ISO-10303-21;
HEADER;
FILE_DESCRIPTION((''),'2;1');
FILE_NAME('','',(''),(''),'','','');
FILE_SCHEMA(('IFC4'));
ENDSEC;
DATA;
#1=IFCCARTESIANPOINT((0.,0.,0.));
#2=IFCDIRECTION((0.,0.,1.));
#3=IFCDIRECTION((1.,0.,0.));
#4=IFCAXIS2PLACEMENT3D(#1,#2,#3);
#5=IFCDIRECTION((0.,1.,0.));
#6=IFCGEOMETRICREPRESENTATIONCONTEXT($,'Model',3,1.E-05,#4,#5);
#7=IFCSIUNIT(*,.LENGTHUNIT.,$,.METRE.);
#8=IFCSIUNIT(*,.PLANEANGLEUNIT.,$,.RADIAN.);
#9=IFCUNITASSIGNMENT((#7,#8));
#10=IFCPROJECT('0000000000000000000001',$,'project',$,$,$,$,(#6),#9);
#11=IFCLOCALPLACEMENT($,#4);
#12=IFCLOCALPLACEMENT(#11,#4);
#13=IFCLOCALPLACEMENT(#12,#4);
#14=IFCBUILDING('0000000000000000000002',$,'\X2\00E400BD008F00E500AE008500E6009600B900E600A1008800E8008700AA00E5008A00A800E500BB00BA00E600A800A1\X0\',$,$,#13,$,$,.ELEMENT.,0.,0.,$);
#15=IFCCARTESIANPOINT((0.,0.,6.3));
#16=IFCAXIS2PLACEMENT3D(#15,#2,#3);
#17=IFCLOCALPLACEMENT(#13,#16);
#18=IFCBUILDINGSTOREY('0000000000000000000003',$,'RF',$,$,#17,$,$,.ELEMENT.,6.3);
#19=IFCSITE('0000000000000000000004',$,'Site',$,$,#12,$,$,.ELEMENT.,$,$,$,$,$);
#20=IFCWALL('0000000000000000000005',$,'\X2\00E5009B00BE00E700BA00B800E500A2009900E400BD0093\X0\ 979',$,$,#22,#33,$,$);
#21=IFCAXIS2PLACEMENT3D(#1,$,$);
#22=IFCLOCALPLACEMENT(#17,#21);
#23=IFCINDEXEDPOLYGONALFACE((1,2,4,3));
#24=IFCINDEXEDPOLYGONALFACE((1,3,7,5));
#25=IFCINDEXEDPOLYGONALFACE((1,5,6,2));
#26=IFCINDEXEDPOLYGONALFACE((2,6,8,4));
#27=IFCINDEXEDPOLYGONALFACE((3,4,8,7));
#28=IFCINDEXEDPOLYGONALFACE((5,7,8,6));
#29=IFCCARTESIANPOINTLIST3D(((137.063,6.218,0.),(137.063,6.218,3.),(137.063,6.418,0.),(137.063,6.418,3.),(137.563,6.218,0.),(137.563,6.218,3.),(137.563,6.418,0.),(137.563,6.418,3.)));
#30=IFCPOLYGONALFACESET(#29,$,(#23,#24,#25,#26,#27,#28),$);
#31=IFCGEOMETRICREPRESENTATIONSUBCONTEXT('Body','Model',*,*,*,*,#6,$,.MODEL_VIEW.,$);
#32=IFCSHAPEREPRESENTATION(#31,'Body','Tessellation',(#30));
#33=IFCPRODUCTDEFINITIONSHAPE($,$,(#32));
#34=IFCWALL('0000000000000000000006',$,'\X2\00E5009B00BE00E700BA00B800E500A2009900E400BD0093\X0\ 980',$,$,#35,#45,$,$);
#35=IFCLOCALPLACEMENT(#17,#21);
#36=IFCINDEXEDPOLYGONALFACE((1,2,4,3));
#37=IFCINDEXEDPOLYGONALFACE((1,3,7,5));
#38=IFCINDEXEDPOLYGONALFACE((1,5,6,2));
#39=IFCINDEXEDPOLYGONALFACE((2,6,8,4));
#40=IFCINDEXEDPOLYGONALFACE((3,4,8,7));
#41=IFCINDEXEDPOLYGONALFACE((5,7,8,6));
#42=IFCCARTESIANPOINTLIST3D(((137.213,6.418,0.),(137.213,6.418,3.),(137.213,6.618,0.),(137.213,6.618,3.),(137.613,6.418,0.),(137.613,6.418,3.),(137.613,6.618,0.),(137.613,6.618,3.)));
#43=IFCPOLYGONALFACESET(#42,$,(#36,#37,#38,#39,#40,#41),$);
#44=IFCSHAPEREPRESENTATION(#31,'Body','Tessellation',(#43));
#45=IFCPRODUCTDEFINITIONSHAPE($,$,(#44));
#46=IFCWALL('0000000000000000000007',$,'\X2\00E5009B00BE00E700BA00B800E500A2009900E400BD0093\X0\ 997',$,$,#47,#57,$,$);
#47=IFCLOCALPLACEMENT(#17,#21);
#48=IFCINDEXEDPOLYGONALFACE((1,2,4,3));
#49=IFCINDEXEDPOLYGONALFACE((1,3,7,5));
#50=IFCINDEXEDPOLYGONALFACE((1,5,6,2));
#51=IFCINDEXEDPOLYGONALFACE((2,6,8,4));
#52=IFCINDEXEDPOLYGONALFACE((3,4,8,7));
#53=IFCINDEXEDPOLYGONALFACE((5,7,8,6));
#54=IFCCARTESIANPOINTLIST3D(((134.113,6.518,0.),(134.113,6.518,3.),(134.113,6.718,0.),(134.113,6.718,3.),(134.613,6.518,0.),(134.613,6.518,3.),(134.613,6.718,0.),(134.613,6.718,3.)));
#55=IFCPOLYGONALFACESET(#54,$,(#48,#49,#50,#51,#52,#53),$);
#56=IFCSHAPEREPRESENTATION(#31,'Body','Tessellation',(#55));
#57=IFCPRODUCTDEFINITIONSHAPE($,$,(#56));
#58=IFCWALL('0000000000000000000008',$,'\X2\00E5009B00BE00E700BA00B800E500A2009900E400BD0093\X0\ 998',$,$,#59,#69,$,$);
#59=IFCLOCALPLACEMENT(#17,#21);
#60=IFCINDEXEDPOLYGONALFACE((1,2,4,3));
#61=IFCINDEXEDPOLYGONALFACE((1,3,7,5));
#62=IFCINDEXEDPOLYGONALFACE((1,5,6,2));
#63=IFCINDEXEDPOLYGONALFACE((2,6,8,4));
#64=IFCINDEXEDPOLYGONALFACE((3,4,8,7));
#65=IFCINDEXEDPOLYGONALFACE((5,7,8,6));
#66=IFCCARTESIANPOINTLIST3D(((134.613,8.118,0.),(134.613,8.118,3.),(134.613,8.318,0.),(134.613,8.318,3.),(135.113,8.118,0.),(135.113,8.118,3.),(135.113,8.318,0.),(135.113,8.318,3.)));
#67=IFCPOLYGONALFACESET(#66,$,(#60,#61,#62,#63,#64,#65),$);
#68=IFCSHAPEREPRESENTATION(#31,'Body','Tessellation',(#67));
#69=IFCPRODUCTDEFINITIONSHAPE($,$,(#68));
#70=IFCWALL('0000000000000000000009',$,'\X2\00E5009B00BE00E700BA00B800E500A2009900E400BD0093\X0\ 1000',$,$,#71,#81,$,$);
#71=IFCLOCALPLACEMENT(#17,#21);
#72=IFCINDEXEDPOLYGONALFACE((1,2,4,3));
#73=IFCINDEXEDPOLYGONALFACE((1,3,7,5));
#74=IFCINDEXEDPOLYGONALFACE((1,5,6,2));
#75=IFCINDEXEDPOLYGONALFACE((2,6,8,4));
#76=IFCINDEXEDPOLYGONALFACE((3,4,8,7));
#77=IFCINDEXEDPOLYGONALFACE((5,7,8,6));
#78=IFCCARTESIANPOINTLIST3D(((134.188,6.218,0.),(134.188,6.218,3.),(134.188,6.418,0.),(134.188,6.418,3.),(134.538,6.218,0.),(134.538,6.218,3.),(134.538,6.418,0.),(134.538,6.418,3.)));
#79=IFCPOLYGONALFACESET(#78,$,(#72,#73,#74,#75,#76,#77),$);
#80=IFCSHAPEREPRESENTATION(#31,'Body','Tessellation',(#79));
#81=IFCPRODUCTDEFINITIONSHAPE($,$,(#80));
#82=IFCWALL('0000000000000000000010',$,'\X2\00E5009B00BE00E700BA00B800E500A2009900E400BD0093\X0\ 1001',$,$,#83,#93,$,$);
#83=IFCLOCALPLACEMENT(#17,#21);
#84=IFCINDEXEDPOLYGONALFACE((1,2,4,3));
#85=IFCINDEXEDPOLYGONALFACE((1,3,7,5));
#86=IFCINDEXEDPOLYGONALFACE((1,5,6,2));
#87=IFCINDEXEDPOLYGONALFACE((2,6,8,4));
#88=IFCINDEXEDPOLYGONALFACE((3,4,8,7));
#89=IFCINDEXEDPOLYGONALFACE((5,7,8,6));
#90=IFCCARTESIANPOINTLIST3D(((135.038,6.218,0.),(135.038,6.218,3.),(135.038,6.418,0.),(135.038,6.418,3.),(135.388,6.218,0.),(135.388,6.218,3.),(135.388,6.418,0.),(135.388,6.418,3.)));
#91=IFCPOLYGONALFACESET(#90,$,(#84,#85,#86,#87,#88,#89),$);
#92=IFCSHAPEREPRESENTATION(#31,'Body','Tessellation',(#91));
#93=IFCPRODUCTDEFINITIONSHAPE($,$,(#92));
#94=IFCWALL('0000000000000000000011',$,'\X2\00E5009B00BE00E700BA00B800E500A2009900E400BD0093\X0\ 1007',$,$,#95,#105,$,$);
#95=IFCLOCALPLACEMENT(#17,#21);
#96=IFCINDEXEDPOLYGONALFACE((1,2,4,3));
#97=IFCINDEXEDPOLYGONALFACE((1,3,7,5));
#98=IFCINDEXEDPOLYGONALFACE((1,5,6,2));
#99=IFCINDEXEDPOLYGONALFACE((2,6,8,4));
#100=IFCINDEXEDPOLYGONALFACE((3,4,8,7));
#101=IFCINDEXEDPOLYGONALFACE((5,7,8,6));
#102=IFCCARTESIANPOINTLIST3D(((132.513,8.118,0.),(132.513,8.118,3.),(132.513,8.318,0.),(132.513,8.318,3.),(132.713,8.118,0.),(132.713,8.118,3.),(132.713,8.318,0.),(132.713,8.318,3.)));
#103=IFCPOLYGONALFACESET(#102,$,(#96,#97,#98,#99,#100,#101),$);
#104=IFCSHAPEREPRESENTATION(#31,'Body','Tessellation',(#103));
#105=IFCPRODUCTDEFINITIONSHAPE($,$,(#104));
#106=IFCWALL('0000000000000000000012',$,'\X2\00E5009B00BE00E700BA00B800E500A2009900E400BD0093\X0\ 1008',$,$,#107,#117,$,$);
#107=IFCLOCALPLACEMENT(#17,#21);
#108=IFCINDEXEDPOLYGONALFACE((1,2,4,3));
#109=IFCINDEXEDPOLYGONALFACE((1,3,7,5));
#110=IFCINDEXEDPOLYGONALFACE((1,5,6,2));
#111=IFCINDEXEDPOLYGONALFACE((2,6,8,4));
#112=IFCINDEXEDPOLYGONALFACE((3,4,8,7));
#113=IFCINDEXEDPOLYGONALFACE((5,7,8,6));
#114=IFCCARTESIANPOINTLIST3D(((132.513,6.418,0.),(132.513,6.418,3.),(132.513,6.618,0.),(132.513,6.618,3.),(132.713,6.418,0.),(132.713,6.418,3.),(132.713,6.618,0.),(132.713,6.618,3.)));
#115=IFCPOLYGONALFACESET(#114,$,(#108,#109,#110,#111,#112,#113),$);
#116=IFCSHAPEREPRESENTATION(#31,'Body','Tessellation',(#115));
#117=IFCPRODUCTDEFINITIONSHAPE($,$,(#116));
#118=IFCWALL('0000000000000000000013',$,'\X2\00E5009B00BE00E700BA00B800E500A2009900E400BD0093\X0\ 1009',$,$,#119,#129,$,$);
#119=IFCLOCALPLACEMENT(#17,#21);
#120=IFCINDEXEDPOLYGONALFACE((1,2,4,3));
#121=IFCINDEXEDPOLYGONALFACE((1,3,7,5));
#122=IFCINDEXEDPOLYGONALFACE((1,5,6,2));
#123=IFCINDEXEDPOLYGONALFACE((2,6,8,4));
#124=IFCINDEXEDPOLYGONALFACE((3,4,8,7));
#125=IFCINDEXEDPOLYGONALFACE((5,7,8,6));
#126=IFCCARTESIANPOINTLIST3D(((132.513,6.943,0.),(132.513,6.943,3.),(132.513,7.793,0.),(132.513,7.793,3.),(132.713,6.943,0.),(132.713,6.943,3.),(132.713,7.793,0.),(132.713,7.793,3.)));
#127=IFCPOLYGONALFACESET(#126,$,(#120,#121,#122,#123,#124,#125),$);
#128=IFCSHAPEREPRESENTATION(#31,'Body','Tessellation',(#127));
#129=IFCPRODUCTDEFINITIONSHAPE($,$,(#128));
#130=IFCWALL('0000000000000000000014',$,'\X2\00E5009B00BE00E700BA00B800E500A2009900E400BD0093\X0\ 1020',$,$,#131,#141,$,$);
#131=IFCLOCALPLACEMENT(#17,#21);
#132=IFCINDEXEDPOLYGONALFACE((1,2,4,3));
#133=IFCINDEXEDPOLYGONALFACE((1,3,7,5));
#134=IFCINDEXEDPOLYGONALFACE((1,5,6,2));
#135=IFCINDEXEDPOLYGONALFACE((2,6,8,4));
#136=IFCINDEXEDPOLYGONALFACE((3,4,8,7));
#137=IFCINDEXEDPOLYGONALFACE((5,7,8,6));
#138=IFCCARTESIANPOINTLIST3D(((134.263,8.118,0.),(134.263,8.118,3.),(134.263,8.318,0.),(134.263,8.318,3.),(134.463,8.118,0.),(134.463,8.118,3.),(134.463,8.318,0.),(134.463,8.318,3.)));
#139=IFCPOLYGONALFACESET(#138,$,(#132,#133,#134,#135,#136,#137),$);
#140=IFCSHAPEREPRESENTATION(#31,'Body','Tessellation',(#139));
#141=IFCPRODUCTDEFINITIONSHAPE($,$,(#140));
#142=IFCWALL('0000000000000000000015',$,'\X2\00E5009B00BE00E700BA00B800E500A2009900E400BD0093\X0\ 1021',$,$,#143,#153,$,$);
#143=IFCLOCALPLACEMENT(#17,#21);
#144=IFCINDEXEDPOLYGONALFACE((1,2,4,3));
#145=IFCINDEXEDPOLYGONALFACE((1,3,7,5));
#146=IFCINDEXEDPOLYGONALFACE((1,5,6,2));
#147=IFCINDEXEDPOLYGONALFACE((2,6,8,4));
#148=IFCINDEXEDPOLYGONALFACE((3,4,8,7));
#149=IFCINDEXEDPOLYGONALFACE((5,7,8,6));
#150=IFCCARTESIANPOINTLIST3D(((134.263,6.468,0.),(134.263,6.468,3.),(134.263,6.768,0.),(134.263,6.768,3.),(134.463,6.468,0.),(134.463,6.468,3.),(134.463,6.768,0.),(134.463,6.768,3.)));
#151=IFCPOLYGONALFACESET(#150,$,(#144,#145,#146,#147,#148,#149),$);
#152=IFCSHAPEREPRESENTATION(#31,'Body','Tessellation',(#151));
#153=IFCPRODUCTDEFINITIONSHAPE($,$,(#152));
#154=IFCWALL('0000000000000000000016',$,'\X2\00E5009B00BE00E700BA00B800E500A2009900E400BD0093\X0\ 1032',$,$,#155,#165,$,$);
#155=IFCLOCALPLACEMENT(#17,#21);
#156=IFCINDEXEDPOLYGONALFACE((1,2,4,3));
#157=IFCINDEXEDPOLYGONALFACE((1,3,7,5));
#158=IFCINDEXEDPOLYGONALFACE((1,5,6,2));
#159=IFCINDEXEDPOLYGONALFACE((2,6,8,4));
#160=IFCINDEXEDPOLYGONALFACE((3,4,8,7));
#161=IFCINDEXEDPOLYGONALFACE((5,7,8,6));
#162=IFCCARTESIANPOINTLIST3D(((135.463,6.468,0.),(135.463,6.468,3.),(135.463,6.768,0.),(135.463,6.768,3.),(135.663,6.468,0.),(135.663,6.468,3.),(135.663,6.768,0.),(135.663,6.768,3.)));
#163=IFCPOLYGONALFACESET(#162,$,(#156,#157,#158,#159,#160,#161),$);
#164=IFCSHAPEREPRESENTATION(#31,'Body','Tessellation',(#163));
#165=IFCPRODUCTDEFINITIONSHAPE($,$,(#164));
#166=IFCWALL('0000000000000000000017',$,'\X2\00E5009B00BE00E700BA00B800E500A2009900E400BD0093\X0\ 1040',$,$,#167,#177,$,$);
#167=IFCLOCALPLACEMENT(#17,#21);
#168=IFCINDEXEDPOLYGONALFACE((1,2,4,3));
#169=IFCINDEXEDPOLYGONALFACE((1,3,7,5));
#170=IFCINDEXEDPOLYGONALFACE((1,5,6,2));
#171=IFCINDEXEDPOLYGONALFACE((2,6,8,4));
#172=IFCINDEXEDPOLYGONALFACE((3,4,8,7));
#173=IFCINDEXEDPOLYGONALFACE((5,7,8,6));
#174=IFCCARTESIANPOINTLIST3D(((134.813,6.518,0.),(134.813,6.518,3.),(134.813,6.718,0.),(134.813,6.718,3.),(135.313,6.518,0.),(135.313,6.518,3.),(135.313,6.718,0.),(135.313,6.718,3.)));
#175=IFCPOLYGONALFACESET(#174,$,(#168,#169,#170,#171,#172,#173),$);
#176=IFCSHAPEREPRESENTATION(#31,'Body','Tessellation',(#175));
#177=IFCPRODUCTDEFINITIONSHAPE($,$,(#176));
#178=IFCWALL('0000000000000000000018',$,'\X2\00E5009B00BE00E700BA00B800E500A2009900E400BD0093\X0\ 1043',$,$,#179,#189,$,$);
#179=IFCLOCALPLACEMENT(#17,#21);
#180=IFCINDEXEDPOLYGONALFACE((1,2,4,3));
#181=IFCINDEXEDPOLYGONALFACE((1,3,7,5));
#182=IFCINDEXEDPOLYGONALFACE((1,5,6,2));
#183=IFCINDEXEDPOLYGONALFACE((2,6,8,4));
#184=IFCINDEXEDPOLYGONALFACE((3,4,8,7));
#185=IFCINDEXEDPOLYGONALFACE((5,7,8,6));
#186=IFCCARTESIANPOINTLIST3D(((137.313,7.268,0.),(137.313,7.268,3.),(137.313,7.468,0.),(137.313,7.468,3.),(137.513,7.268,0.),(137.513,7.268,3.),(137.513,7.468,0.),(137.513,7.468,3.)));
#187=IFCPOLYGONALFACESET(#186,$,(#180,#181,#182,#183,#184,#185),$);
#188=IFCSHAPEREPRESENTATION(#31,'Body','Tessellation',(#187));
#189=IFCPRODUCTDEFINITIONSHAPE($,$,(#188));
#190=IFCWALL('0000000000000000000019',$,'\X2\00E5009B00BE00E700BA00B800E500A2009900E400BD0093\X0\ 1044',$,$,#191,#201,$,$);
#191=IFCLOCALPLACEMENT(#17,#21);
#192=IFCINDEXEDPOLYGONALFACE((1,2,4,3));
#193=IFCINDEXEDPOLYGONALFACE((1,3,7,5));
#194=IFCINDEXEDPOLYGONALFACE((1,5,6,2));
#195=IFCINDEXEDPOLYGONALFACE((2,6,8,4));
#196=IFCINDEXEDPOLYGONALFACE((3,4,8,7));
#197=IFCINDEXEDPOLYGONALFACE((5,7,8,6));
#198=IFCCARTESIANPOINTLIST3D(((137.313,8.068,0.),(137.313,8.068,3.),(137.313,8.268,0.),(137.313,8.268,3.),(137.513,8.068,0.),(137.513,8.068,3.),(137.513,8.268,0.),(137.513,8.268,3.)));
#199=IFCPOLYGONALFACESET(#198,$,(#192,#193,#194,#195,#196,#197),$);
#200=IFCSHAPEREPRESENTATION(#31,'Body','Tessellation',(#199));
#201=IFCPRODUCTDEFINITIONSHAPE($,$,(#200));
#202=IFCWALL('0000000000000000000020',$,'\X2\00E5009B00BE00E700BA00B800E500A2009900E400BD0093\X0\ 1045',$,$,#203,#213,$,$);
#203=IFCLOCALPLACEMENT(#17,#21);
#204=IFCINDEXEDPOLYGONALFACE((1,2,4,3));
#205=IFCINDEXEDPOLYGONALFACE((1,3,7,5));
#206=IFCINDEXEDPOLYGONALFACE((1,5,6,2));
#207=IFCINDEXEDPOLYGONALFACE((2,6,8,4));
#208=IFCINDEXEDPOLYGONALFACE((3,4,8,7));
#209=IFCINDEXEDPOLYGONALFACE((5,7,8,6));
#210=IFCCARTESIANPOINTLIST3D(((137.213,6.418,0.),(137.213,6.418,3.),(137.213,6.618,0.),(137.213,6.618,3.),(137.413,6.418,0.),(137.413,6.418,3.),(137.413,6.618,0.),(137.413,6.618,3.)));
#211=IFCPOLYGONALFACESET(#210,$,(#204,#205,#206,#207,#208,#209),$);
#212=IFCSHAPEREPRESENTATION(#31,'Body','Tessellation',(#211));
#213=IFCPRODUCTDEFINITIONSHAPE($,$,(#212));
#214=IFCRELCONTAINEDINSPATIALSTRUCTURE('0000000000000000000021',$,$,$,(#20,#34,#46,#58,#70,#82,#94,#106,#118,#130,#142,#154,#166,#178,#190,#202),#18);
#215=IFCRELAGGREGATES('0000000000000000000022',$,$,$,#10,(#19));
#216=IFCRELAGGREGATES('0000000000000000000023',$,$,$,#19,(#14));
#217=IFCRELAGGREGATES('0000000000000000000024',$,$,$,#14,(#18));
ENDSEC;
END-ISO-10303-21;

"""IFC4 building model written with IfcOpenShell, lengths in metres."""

from ifc_helpers import new_model, si_unit, direction, frame, frame_2d, origin_with_axes, place, context, subcontext, project, spatial, rectangle, extrude, element, save


model = new_model("IFC4")

# Units and contexts
model_context = context("Model", 3, precision=1e-05, world=origin_with_axes(), true_north=direction((0.0, 1.0, 0.0)))
body_context = subcontext(model_context, "Body", "Model", "MODEL_VIEW")
ifc_project = project(units=[si_unit("LENGTHUNIT", "METRE"), si_unit("PLANEANGLEUNIT", "RADIAN")], contexts=[model_context])

# Site, building, storey
placement = place(None, origin_with_axes())
site_placement = place(placement, origin_with_axes())
site = spatial("IfcSite", under=ifc_project, at=site_placement, Name="Site", CompositionType="ELEMENT")
building_placement = place(site_placement, origin_with_axes())
building = spatial("IfcBuilding", under=site, at=building_placement, Name="ä½\u008få®\u0085æ\u0096¹æ¡\u0088è\u0087ªå\u008a¨å»ºæ¨¡", CompositionType="ELEMENT", ElevationOfRefHeight=0.0, ElevationOfTerrain=0.0)
storey_placement = place(building_placement, frame((0.0, 0.0, 6.3), z_axis=(0.0, 0.0, 1.0), x_axis=(1.0, 0.0, 0.0)))
storey = spatial("IfcBuildingStorey", under=building, at=storey_placement, Name="RF", CompositionType="ELEMENT", Elevation=6.3)

# Walls
wall_1_placement = place(storey_placement, frame((137.313, 6.318, 0.0), z_axis=(0.0, 0.0, 1.0), x_axis=(1.0, 0.0, 0.0)))
element("IfcWall", 1, at=wall_1_placement, inside=storey, Name="å\u009b¾çº¸å¢\u0099ä½\u0093 979", context=body_context, shape_type="SweptSolid", body=[
    extrude(rectangle(XDim=0.5, YDim=0.2, at=frame_2d((0.0, 0.0), x_axis=(1.0, 0.0, 0.0))), frame((0.0, 0.0, 0.0), z_axis=(0.0, 0.0, 1.0)), (0.0, 0.0, 1.0), 3.0),
])
wall_2_placement = place(storey_placement, frame((137.413, 6.518, 0.0), z_axis=(0.0, 0.0, 1.0), x_axis=(1.0, 0.0, 0.0)))
element("IfcWall", 2, at=wall_2_placement, inside=storey, Name="å\u009b¾çº¸å¢\u0099ä½\u0093 980", context=body_context, shape_type="SweptSolid", body=[
    extrude(rectangle(XDim=0.4, YDim=0.2, at=frame_2d((0.0, 0.0), x_axis=(1.0, 0.0, 0.0))), frame((0.0, 0.0, 0.0), z_axis=(0.0, 0.0, 1.0)), (0.0, 0.0, 1.0), 3.0),
])
for number, where, z_axis, x_axis, name in (
    (3, (134.363, 6.618, 0.0), (0.0, 0.0, 1.0), (1.0, 0.0, 0.0), "å\u009b¾çº¸å¢\u0099ä½\u0093 997"),
    (4, (134.863, 8.218, 0.0), (0.0, 0.0, 1.0), (-1.0, 0.0, 0.0), "å\u009b¾çº¸å¢\u0099ä½\u0093 998"),
):
    element("IfcWall", number, at=place(storey_placement, frame(where, z_axis=z_axis, x_axis=x_axis)), inside=storey, Name=name, context=body_context, shape_type="SweptSolid", body=[
        extrude(rectangle(XDim=0.5, YDim=0.2, at=frame_2d((0.0, 0.0), x_axis=(1.0, 0.0, 0.0))), frame((0.0, 0.0, 0.0), z_axis=(0.0, 0.0, 1.0)), (0.0, 0.0, 1.0), 3.0),
    ])
for number, where, z_axis, x_axis, name in (
    (5, (134.363, 6.318, 0.0), (0.0, 0.0, 1.0), (1.0, 0.0, 0.0), "å\u009b¾çº¸å¢\u0099ä½\u0093 1000"),
    (6, (135.213, 6.318, 0.0), (0.0, 0.0, 1.0), (1.0, 0.0, 0.0), "å\u009b¾çº¸å¢\u0099ä½\u0093 1001"),
):
    element("IfcWall", number, at=place(storey_placement, frame(where, z_axis=z_axis, x_axis=x_axis)), inside=storey, Name=name, context=body_context, shape_type="SweptSolid", body=[
        extrude(rectangle(XDim=0.35, YDim=0.2, at=frame_2d((0.0, 0.0), x_axis=(1.0, 0.0, 0.0))), frame((0.0, 0.0, 0.0), z_axis=(0.0, 0.0, 1.0)), (0.0, 0.0, 1.0), 3.0),
    ])
for number, where, z_axis, x_axis, name in (
    (7, (132.613, 8.218, 0.0), (0.0, 0.0, 1.0), (0.0, 1.0, 0.0), "å\u009b¾çº¸å¢\u0099ä½\u0093 1007"),
    (8, (132.613, 6.518, 0.0), (0.0, 0.0, 1.0), (0.0, -1.0, 0.0), "å\u009b¾çº¸å¢\u0099ä½\u0093 1008"),
):
    element("IfcWall", number, at=place(storey_placement, frame(where, z_axis=z_axis, x_axis=x_axis)), inside=storey, Name=name, context=body_context, shape_type="SweptSolid", body=[
        extrude(rectangle(XDim=0.2, YDim=0.2, at=frame_2d((0.0, 0.0), x_axis=(1.0, 0.0, 0.0))), frame((0.0, 0.0, 0.0), z_axis=(0.0, 0.0, 1.0)), (0.0, 0.0, 1.0), 3.0),
    ])
wall_3_placement = place(storey_placement, frame((132.613, 7.368, 0.0), z_axis=(0.0, 0.0, 1.0), x_axis=(0.0, -1.0, 0.0)))
element("IfcWall", 9, at=wall_3_placement, inside=storey, Name="å\u009b¾çº¸å¢\u0099ä½\u0093 1009", context=body_context, shape_type="SweptSolid", body=[
    extrude(rectangle(XDim=0.85, YDim=0.2, at=frame_2d((0.0, 0.0), x_axis=(1.0, 0.0, 0.0))), frame((0.0, 0.0, 0.0), z_axis=(0.0, 0.0, 1.0)), (0.0, 0.0, 1.0), 3.0),
])
for number, where, z_axis, x_axis, name in (
    (10, (134.363, 8.218, 0.0), (0.0, 0.0, 1.0), (0.0, 1.0, 0.0), "å\u009b¾çº¸å¢\u0099ä½\u0093 1020"),
):
    element("IfcWall", number, at=place(storey_placement, frame(where, z_axis=z_axis, x_axis=x_axis)), inside=storey, Name=name, context=body_context, shape_type="SweptSolid", body=[
        extrude(rectangle(XDim=0.2, YDim=0.2, at=frame_2d((0.0, 0.0), x_axis=(1.0, 0.0, 0.0))), frame((0.0, 0.0, 0.0), z_axis=(0.0, 0.0, 1.0)), (0.0, 0.0, 1.0), 3.0),
    ])
for number, where, z_axis, x_axis, name in (
    (11, (134.363, 6.618, 0.0), (0.0, 0.0, 1.0), (0.0, -1.0, 0.0), "å\u009b¾çº¸å¢\u0099ä½\u0093 1021"),
    (12, (135.563, 6.618, 0.0), (0.0, 0.0, 1.0), (0.0, -1.0, 0.0), "å\u009b¾çº¸å¢\u0099ä½\u0093 1032"),
):
    element("IfcWall", number, at=place(storey_placement, frame(where, z_axis=z_axis, x_axis=x_axis)), inside=storey, Name=name, context=body_context, shape_type="SweptSolid", body=[
        extrude(rectangle(XDim=0.3, YDim=0.2, at=frame_2d((0.0, 0.0), x_axis=(1.0, 0.0, 0.0))), frame((0.0, 0.0, 0.0), z_axis=(0.0, 0.0, 1.0)), (0.0, 0.0, 1.0), 3.0),
    ])
wall_4_placement = place(storey_placement, frame((135.063, 6.618, 0.0), z_axis=(0.0, 0.0, 1.0), x_axis=(1.0, 0.0, 0.0)))
element("IfcWall", 13, at=wall_4_placement, inside=storey, Name="å\u009b¾çº¸å¢\u0099ä½\u0093 1040", context=body_context, shape_type="SweptSolid", body=[
    extrude(rectangle(XDim=0.5, YDim=0.2, at=frame_2d((0.0, 0.0), x_axis=(1.0, 0.0, 0.0))), frame((0.0, 0.0, 0.0), z_axis=(0.0, 0.0, 1.0)), (0.0, 0.0, 1.0), 3.0),
])
for number, where, z_axis, x_axis, name in (
    (14, (137.413, 7.368, 0.0), (0.0, 0.0, 1.0), (-1.0, 0.0, 0.0), "å\u009b¾çº¸å¢\u0099ä½\u0093 1043"),
    (15, (137.413, 8.168, 0.0), (0.0, 0.0, 1.0), (-1.0, 0.0, 0.0), "å\u009b¾çº¸å¢\u0099ä½\u0093 1044"),
    (16, (137.313, 6.518, 0.0), (0.0, 0.0, 1.0), (0.0, -1.0, 0.0), "å\u009b¾çº¸å¢\u0099ä½\u0093 1045"),
):
    element("IfcWall", number, at=place(storey_placement, frame(where, z_axis=z_axis, x_axis=x_axis)), inside=storey, Name=name, context=body_context, shape_type="SweptSolid", body=[
        extrude(rectangle(XDim=0.2, YDim=0.2, at=frame_2d((0.0, 0.0), x_axis=(1.0, 0.0, 0.0))), frame((0.0, 0.0, 0.0), z_axis=(0.0, 0.0, 1.0)), (0.0, 0.0, 1.0), 3.0),
    ])

save(model, "model.ifc")
